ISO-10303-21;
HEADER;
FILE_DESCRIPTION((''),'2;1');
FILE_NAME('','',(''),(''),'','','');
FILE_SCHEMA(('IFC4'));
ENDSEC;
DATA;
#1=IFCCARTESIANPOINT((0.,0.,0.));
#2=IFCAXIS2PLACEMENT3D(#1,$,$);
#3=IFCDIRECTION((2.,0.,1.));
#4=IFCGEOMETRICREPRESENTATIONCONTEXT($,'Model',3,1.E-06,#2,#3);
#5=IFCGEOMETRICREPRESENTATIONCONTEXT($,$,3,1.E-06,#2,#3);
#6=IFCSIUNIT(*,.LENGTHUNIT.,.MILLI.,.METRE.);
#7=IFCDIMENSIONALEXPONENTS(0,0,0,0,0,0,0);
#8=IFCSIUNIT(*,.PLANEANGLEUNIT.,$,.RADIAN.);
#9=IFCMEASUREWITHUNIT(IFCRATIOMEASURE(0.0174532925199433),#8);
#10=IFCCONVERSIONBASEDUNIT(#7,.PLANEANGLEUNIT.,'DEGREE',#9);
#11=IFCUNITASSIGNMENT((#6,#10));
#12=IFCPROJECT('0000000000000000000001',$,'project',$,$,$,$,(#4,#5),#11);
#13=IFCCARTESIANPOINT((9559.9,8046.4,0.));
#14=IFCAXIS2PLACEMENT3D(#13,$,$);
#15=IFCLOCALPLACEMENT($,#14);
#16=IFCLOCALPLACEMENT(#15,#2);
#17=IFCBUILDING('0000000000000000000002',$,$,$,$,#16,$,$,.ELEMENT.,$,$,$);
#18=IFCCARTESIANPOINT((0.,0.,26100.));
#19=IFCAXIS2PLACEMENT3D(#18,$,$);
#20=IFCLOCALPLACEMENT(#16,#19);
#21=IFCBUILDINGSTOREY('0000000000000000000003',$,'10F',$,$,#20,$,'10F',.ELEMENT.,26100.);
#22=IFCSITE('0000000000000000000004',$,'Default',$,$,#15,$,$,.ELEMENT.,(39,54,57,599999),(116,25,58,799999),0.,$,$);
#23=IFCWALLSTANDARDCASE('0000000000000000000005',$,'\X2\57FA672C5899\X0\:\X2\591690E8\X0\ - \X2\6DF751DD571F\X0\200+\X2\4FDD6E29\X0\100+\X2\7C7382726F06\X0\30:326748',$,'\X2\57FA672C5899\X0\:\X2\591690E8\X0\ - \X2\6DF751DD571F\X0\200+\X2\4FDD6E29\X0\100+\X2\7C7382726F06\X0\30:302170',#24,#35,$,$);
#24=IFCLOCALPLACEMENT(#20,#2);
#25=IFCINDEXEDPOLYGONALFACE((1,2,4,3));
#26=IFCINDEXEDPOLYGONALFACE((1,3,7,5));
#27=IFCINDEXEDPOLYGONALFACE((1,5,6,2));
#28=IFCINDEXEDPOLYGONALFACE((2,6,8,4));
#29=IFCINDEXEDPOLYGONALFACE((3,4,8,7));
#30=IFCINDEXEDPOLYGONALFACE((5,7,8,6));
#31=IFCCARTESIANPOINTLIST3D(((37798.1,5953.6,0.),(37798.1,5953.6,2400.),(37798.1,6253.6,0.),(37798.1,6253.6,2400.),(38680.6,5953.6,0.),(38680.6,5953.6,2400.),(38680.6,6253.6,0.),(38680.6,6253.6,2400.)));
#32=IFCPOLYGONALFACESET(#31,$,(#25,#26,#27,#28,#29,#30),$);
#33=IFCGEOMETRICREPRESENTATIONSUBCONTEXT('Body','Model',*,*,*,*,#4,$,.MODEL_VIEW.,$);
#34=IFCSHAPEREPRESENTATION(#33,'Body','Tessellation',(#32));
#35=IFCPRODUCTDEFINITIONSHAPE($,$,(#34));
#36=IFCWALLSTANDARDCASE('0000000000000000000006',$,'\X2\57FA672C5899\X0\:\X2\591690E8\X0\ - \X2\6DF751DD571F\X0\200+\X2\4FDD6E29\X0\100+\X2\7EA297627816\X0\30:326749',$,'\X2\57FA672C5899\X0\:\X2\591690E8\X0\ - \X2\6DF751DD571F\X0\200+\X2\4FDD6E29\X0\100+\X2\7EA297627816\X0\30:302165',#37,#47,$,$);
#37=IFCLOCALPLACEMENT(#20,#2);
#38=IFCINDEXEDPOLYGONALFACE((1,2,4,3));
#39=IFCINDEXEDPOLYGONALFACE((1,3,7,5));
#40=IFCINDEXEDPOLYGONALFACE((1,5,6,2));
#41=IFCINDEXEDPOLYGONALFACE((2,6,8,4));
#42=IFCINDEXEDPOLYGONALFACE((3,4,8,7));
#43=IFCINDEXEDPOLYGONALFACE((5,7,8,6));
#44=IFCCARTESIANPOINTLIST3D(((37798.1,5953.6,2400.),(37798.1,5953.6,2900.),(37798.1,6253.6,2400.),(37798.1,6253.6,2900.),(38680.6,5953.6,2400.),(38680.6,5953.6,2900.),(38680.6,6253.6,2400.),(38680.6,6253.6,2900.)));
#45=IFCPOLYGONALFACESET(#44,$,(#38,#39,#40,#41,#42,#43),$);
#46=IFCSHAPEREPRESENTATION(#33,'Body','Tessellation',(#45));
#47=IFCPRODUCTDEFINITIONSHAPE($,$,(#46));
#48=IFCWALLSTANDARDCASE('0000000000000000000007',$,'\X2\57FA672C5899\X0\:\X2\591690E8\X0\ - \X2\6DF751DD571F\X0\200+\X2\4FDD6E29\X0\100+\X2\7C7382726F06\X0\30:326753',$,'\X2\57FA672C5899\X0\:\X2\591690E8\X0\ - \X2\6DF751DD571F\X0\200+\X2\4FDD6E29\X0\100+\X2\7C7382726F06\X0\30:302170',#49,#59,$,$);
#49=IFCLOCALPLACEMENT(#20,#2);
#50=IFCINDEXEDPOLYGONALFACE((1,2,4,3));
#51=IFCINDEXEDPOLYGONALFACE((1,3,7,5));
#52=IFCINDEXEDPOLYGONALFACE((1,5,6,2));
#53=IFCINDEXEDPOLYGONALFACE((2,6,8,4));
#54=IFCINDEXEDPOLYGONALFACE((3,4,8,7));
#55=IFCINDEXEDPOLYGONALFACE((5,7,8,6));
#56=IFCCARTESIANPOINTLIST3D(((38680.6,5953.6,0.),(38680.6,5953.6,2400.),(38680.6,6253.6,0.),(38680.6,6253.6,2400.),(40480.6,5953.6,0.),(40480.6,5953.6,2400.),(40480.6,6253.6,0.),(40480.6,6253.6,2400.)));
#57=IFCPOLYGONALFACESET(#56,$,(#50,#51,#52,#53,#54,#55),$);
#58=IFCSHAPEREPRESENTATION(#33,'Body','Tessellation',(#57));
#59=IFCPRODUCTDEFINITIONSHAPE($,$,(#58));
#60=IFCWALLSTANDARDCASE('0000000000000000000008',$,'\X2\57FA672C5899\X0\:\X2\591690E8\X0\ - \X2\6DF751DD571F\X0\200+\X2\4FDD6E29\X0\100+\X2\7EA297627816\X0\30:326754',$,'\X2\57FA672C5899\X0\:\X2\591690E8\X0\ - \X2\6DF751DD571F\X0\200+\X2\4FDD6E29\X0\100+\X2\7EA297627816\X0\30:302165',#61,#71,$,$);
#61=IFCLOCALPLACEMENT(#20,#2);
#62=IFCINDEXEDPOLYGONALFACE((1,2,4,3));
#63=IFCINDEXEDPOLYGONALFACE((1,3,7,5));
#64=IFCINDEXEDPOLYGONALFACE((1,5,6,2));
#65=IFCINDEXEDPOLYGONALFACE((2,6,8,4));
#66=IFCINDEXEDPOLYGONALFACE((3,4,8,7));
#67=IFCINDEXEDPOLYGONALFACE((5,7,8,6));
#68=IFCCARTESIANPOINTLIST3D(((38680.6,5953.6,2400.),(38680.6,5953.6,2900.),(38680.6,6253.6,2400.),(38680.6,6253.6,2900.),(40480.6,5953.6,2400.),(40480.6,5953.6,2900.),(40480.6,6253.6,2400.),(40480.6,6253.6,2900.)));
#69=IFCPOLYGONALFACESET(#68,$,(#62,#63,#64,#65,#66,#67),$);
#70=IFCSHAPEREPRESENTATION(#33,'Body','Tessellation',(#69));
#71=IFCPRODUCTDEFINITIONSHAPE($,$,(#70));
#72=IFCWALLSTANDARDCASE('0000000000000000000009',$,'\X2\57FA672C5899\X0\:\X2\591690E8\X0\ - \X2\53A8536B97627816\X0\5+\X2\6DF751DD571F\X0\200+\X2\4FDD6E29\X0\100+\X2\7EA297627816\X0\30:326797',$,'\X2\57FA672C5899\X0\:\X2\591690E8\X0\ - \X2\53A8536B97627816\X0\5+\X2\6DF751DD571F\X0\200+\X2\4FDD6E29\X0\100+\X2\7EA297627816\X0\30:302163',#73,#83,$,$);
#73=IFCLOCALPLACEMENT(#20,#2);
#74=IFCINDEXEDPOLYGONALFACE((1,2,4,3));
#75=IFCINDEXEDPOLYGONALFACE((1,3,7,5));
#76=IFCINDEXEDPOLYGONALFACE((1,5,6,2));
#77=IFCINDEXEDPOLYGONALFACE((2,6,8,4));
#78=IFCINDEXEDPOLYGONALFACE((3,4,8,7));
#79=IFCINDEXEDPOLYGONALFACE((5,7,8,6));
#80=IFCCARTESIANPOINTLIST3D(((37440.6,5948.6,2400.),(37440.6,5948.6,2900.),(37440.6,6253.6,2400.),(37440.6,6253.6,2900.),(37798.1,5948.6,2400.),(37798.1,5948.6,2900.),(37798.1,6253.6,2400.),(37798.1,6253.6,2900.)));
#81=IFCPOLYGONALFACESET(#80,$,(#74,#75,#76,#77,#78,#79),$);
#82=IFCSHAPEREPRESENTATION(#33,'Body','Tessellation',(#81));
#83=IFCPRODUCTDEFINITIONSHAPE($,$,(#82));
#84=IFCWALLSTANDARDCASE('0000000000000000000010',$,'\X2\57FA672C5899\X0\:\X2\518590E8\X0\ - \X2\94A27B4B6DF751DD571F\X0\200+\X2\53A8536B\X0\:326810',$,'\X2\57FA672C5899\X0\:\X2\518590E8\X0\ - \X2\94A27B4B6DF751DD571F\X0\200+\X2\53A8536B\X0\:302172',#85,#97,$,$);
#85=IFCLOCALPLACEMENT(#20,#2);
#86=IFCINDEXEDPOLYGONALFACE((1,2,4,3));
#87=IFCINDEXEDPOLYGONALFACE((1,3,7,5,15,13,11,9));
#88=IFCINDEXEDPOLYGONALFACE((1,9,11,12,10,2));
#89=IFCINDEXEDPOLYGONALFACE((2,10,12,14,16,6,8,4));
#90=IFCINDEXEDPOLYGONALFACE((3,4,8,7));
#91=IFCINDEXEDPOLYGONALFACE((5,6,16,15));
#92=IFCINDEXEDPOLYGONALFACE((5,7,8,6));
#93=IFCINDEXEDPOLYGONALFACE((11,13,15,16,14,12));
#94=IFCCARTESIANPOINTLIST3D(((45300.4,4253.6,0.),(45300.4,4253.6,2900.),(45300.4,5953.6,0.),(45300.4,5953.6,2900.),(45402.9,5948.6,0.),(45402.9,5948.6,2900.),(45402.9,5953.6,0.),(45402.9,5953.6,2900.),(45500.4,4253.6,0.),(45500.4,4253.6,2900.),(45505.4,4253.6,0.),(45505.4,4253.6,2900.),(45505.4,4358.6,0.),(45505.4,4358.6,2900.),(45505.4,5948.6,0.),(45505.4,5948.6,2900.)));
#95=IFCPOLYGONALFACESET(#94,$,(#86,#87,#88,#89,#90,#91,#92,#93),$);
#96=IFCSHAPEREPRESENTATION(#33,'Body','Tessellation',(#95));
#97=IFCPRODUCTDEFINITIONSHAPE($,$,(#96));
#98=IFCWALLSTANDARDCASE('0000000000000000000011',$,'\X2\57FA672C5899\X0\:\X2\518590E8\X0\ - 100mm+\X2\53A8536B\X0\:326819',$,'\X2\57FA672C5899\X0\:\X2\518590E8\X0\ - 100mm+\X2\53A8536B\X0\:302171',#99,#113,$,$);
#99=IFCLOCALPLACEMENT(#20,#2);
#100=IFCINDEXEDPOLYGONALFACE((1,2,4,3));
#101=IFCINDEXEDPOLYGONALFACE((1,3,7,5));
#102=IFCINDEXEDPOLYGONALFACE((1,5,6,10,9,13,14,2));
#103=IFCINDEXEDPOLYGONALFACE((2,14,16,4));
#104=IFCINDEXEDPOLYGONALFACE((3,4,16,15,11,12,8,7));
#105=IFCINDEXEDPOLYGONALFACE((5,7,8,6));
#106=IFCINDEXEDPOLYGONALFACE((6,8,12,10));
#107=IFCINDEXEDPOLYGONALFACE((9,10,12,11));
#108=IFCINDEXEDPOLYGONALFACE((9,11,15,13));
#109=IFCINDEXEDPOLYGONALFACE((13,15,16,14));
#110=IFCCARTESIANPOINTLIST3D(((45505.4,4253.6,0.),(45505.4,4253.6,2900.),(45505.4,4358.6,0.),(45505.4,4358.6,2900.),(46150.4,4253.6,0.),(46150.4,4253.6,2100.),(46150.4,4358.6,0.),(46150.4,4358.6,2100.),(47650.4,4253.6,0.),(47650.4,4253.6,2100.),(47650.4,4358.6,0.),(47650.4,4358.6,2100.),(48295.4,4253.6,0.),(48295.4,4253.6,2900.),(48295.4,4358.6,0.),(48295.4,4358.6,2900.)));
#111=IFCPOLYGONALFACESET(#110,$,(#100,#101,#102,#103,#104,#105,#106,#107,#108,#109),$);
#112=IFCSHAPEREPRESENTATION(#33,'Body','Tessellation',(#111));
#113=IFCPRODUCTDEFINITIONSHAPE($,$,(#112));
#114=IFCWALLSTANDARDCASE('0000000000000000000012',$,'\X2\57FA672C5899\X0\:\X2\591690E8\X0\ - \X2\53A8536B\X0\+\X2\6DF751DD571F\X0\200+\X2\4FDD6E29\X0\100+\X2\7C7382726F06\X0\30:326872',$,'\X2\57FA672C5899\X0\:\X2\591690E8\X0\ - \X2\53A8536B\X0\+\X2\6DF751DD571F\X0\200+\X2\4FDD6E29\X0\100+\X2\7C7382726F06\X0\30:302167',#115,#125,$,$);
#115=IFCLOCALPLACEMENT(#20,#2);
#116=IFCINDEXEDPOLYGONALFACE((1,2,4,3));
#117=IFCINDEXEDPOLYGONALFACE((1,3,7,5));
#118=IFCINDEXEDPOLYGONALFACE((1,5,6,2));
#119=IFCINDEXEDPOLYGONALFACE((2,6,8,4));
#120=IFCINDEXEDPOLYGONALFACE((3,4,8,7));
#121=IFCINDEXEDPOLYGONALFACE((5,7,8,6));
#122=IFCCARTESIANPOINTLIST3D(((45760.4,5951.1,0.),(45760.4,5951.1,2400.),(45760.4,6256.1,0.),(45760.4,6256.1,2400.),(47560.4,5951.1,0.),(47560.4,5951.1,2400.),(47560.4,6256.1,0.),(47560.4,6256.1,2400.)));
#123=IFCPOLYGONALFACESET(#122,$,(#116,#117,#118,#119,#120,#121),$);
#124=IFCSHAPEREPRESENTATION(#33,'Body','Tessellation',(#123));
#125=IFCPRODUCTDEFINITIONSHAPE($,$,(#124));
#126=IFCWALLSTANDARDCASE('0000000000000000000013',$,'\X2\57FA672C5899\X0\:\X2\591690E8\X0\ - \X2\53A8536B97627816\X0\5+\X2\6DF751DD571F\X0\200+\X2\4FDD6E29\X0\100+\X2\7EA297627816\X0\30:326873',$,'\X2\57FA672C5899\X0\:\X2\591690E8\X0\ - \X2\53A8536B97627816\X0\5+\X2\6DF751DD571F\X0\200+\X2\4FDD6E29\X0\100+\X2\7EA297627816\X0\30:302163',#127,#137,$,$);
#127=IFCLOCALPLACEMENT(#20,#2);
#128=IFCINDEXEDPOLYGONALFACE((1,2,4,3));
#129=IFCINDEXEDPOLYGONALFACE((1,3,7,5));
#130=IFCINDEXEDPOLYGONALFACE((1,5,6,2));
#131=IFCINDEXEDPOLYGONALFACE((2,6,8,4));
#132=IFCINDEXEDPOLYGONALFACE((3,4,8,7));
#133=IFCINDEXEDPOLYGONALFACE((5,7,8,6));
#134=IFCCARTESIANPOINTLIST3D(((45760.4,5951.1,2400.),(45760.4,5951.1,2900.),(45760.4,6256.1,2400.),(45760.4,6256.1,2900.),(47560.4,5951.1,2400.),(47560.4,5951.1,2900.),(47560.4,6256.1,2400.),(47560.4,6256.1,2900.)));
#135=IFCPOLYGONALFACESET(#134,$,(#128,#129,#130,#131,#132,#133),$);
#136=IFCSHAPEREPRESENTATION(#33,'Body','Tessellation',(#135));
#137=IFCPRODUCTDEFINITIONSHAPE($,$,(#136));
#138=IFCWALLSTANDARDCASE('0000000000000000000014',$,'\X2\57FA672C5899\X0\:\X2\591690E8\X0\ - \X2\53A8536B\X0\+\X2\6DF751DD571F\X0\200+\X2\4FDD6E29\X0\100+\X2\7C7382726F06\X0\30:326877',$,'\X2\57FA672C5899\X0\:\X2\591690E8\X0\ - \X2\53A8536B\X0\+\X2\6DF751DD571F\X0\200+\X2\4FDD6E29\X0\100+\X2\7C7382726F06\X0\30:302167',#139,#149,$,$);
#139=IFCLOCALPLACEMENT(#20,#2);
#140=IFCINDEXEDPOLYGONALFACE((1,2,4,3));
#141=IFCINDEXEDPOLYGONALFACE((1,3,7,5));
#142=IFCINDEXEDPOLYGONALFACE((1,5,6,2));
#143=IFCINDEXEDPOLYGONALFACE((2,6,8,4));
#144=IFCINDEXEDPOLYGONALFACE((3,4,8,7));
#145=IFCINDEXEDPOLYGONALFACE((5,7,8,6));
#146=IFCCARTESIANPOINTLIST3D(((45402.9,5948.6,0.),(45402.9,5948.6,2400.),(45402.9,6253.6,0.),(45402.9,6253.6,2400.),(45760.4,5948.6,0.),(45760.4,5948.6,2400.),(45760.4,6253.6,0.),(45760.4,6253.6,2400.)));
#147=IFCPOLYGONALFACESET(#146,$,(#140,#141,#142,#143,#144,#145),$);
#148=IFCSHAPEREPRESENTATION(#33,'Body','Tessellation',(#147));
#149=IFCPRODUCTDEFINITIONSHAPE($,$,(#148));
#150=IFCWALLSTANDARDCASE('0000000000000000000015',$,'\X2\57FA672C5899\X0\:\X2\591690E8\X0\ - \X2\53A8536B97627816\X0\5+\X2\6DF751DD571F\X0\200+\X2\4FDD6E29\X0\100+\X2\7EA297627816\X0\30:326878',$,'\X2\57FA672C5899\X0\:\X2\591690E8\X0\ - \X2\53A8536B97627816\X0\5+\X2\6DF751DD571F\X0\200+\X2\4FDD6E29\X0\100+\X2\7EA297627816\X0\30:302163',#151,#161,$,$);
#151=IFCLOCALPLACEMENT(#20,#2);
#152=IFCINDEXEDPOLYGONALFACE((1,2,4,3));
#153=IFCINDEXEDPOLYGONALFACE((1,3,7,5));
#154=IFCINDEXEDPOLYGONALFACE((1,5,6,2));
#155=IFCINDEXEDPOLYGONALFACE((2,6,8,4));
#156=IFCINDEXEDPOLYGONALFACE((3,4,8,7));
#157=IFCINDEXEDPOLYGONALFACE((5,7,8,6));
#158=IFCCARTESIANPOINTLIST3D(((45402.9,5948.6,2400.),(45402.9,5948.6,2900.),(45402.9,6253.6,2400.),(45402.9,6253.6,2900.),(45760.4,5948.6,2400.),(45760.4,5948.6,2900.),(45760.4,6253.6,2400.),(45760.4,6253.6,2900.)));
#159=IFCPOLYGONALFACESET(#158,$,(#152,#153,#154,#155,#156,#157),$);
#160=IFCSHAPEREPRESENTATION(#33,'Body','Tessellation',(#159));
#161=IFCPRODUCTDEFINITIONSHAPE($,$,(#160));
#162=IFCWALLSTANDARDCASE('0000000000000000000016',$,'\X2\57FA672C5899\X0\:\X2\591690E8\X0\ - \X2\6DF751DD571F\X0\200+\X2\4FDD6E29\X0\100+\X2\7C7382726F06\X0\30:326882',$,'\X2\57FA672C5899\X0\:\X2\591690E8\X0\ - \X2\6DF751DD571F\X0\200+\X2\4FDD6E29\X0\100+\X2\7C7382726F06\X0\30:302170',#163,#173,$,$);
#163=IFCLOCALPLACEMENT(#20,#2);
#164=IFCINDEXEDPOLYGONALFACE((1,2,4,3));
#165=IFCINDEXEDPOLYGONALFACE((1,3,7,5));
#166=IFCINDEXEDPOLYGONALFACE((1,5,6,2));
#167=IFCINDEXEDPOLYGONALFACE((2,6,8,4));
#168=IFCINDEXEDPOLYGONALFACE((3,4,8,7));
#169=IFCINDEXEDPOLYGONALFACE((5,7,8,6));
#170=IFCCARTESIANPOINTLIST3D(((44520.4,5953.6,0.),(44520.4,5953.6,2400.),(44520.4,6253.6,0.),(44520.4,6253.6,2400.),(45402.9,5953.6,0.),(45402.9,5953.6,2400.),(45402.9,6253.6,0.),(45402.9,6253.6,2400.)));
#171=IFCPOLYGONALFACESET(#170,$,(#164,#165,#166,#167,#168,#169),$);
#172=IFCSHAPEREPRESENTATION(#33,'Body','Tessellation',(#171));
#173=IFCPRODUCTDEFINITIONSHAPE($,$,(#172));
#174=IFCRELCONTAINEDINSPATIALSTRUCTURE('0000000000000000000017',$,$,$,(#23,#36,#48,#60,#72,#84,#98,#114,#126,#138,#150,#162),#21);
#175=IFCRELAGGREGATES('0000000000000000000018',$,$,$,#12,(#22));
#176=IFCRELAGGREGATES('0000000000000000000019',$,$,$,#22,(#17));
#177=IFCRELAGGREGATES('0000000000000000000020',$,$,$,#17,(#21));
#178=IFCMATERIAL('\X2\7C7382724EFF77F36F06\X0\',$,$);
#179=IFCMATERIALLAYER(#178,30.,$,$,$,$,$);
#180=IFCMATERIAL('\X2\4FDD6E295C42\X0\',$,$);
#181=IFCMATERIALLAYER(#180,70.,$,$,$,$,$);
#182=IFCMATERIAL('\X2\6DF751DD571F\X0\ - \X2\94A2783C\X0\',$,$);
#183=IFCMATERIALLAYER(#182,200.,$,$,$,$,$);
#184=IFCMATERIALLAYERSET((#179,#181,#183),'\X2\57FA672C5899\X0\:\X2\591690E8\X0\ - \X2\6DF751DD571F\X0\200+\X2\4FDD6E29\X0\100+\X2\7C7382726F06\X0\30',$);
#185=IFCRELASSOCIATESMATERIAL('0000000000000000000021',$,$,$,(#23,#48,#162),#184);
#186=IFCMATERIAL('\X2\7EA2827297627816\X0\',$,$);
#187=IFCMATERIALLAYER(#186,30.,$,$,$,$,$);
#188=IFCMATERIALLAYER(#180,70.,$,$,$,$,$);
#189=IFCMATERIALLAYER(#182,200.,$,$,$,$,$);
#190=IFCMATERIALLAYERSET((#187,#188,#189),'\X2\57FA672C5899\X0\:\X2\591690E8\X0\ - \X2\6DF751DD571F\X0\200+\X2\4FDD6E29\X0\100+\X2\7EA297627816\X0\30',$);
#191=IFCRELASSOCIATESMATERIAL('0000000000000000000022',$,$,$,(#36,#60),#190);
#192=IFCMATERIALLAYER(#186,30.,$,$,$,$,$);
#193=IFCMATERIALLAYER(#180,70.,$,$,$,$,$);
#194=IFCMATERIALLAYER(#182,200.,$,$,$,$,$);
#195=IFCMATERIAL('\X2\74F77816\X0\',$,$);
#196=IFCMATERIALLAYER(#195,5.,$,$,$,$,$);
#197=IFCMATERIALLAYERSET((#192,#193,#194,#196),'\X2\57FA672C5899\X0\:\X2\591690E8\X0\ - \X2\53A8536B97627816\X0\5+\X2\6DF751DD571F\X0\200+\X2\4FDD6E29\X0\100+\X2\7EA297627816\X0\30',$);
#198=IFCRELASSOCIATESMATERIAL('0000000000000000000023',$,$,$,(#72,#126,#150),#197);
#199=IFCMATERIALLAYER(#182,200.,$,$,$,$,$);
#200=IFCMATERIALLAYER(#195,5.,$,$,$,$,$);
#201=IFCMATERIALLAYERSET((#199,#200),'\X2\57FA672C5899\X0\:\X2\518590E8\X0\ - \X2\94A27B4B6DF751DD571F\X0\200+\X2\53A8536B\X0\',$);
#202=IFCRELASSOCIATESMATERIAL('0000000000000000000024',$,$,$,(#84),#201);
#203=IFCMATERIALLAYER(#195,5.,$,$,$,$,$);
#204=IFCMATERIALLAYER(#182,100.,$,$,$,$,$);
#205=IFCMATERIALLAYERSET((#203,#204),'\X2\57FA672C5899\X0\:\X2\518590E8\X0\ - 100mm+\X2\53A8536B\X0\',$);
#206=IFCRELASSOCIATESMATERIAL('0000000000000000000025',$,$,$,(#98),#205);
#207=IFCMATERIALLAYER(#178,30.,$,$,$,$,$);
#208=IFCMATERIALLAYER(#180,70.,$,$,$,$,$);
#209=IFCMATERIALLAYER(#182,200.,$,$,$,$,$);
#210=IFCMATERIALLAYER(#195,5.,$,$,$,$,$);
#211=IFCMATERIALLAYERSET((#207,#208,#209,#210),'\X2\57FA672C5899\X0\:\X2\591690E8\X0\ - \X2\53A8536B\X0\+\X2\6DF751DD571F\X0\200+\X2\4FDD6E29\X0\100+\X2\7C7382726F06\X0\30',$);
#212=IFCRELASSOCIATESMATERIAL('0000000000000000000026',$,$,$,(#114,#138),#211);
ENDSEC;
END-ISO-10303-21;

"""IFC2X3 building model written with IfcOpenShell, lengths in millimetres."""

from ifc_helpers import new_model, entity, si_unit, converted_unit, direction, frame, frame_2d, origin, place, context, subcontext, project, spatial, polyline, rectangle, outline, extrude, material, layer, layer_set, layer_usage, element, save


model = new_model("IFC2X3")

# Units and contexts
model_context = context("Model", 3, precision=1e-06, world=origin(), true_north=direction((2.0, 0.0, 1.0)))
context_of_model = context(None, 3, precision=1e-06, world=origin(), true_north=direction((2.0, 0.0, 1.0)))
body_context = subcontext(model_context, "Body", "Model", "MODEL_VIEW")
ifc_project = project(units=[si_unit("LENGTHUNIT", "METRE", prefix="MILLI"), converted_unit("PLANEANGLEUNIT", "DEGREE", entity("IfcRatioMeasure", 0.0174532925199433), si_unit("PLANEANGLEUNIT", "RADIAN"), dimensions=[0, 0, 0, 0, 0, 0, 0])], contexts=[model_context, context_of_model])

# Site, building, storey
site_placement = place(None, frame((9559.9, 8046.4, 0.0)))
site = spatial("IfcSite", under=ifc_project, at=site_placement, Name="Default", CompositionType="ELEMENT", RefLatitude=(39, 54, 57, 599999), RefLongitude=(116, 25, 58, 799999), RefElevation=0.0)
building_placement = place(site_placement, origin())
building = spatial("IfcBuilding", under=site, at=building_placement, CompositionType="ELEMENT")
storey_placement = place(building_placement, frame((0.0, 0.0, 26100.0)))
storey = spatial("IfcBuildingStorey", under=building, at=storey_placement, Name="10F", LongName="10F", CompositionType="ELEMENT", Elevation=26100.0)

# Shared definitions
ifc_material_1 = material(Name="红色面砖")
ifc_layer_1 = layer(ifc_material_1, 30.0)
ifc_material_2 = material(Name="保温层")
ifc_layer_2 = layer(ifc_material_2, 70.0)
ifc_material_3 = material(Name="混凝土 - 钢砼")
ifc_layer_3 = layer(ifc_material_3, 200.0)
ifc_layer_set_1 = layer_set([ifc_layer_1, ifc_layer_2, ifc_layer_3], Name="基本墙:外部 - 混凝土200+保温100+红面砖30")

# Walls
ifc_material_4 = material(Name="米色仿石漆")
ifc_layer_4 = layer(ifc_material_4, 30.0)
ifc_layer_5 = layer(ifc_material_2, 70.0)
ifc_layer_6 = layer(ifc_material_3, 200.0)
ifc_layer_set_2 = layer_set([ifc_layer_4, ifc_layer_5, ifc_layer_6], Name="基本墙:外部 - 混凝土200+保温100+米色漆30")
ifc_layer_usage_1 = layer_usage(ifc_layer_set_2, "AXIS2", "POSITIVE", -150.0)
wall_1_placement = place(storey_placement, frame((38680.6, 6103.6, 0.0), z_axis=(0.0, 0.0, 1.0), x_axis=(-1.0, 0.0, 0.0)))
element("IfcWallStandardCase", 1, at=wall_1_placement, inside=storey, material=ifc_layer_usage_1, Name="基本墙:外部 - 混凝土200+保温100+米色漆30:326748", ObjectType="基本墙:外部 - 混凝土200+保温100+米色漆30:302170", context=body_context, shape_type="SweptSolid", body=[
    extrude(rectangle(XDim=882.5, YDim=300.0, at=frame_2d((441.3, 0.0), x_axis=(-1.0, 0.0))), origin(), (0.0, 0.0, 1.0), 2400.0),
])
ifc_layer_usage_2 = layer_usage(ifc_layer_set_1, "AXIS2", "POSITIVE", -150.0)
wall_2_placement = place(storey_placement, frame((38680.6, 6103.6, 2400.0), z_axis=(0.0, 0.0, 1.0), x_axis=(-1.0, 0.0, 0.0)))
element("IfcWallStandardCase", 2, at=wall_2_placement, inside=storey, material=ifc_layer_usage_2, Name="基本墙:外部 - 混凝土200+保温100+红面砖30:326749", ObjectType="基本墙:外部 - 混凝土200+保温100+红面砖30:302165", context=body_context, shape_type="SweptSolid", body=[
    extrude(rectangle(XDim=882.5, YDim=300.0, at=frame_2d((441.3, 0.0), x_axis=(-1.0, 0.0))), origin(), (0.0, 0.0, 1.0), 500.0),
])
ifc_layer_usage_3 = layer_usage(ifc_layer_set_2, "AXIS2", "POSITIVE", -150.0)
wall_3_placement = place(storey_placement, frame((40480.6, 6103.6, 0.0), z_axis=(0.0, 0.0, 1.0), x_axis=(-1.0, 0.0, 0.0)))
element("IfcWallStandardCase", 3, at=wall_3_placement, inside=storey, material=ifc_layer_usage_3, Name="基本墙:外部 - 混凝土200+保温100+米色漆30:326753", ObjectType="基本墙:外部 - 混凝土200+保温100+米色漆30:302170", context=body_context, shape_type="SweptSolid", body=[
    extrude(rectangle(XDim=1800.0, YDim=300.0, at=frame_2d((900.0, 0.0), x_axis=(-1.0, 0.0))), origin(), (0.0, 0.0, 1.0), 2400.0),
])
ifc_layer_usage_4 = layer_usage(ifc_layer_set_1, "AXIS2", "POSITIVE", -150.0)
wall_4_placement = place(storey_placement, frame((40480.6, 6103.6, 2400.0), z_axis=(0.0, 0.0, 1.0), x_axis=(-1.0, 0.0, 0.0)))
element("IfcWallStandardCase", 4, at=wall_4_placement, inside=storey, material=ifc_layer_usage_4, Name="基本墙:外部 - 混凝土200+保温100+红面砖30:326754", ObjectType="基本墙:外部 - 混凝土200+保温100+红面砖30:302165", context=body_context, shape_type="SweptSolid", body=[
    extrude(rectangle(XDim=1800.0, YDim=300.0, at=frame_2d((900.0, 0.0), x_axis=(-1.0, 0.0))), origin(), (0.0, 0.0, 1.0), 500.0),
])
ifc_layer_7 = layer(ifc_material_1, 30.0)
ifc_layer_8 = layer(ifc_material_2, 70.0)
ifc_layer_9 = layer(ifc_material_3, 200.0)
ifc_material_5 = material(Name="瓷砖")
ifc_layer_10 = layer(ifc_material_5, 5.0)
ifc_layer_set_3 = layer_set([ifc_layer_7, ifc_layer_8, ifc_layer_9, ifc_layer_10], Name="基本墙:外部 - 厨卫面砖5+混凝土200+保温100+红面砖30")
ifc_layer_usage_5 = layer_usage(ifc_layer_set_3, "AXIS2", "POSITIVE", -152.5)
wall_5_placement = place(storey_placement, frame((37798.1, 6101.1, 2400.0), z_axis=(0.0, 0.0, 1.0), x_axis=(-1.0, 0.0, 0.0)))
element("IfcWallStandardCase", 5, at=wall_5_placement, inside=storey, material=ifc_layer_usage_5, Name="基本墙:外部 - 厨卫面砖5+混凝土200+保温100+红面砖30:326797", ObjectType="基本墙:外部 - 厨卫面砖5+混凝土200+保温100+红面砖30:302163", context=body_context, shape_type="SweptSolid", body=[
    extrude(rectangle(XDim=357.5, YDim=305.0, at=frame_2d((178.7, 0.0), x_axis=(-1.0, 0.0))), origin(), (0.0, 0.0, 1.0), 500.0),
])

# Wall
ifc_layer_11 = layer(ifc_material_3, 200.0)
ifc_layer_12 = layer(ifc_material_5, 5.0)
ifc_layer_set_4 = layer_set([ifc_layer_11, ifc_layer_12], Name="基本墙:内部 - 钢筋混凝土200+厨卫")
ifc_layer_usage_6 = layer_usage(ifc_layer_set_4, "AXIS2", "POSITIVE", -102.5)
wall_6_placement = place(storey_placement, frame((45402.9, 5953.6, 0.0), z_axis=(0.0, 0.0, 1.0), x_axis=(0.0, -1.0, 0.0)))
element("IfcWallStandardCase", 6, at=wall_6_placement, inside=storey, material=ifc_layer_usage_6, Name="基本墙:内部 - 钢筋混凝土200+厨卫:326810", ObjectType="基本墙:内部 - 钢筋混凝土200+厨卫:302172", context=body_context, shape_type="SweptSolid", body=[
    extrude(outline(polyline([(1700.0, -102.5), (1700.0, 97.5), (1700.0, 102.5), (1595.0, 102.5), (5.0, 102.5), (5.0, 0.0), (0.0, 0.0), (0.0, -102.5), (1700.0, -102.5)])), origin(), (0.0, 0.0, 1.0), 2900.0),
])

# Wall, opening
ifc_layer_13 = layer(ifc_material_5, 5.0)
ifc_layer_14 = layer(ifc_material_3, 100.0)
ifc_layer_set_5 = layer_set([ifc_layer_13, ifc_layer_14], Name="基本墙:内部 - 100mm+厨卫")
ifc_layer_usage_7 = layer_usage(ifc_layer_set_5, "AXIS2", "NEGATIVE", 52.5)
wall_7_placement = place(storey_placement, frame((45505.4, 4306.1, 0.0)))
wall_7 = element("IfcWallStandardCase", 7, at=wall_7_placement, inside=storey, material=ifc_layer_usage_7, Name="基本墙:内部 - 100mm+厨卫:326819", ObjectType="基本墙:内部 - 100mm+厨卫:302171", context=body_context, shape_type="SweptSolid", body=[
    extrude(rectangle(XDim=2790.0, YDim=105.0, at=frame_2d((1395.0, 0.0), x_axis=(-1.0, 0.0))), origin(), (0.0, 0.0, 1.0), 2900.0),
])
opening_1_placement = place(wall_7_placement, frame((645.0, -52.5, 0.0)))
element("IfcOpeningElement", 8, at=opening_1_placement, cuts=wall_7, ObjectType="Opening", context=body_context, shape_type="SweptSolid", body=[
    extrude(rectangle(XDim=2100.0, YDim=1500.0, at=frame_2d((1050.0, 750.0), x_axis=(1.0, 0.0))), frame((0.0, 0.0, 0.0), z_axis=(0.0, 1.0, 0.0), x_axis=(0.0, 0.0, 1.0)), (0.0, 0.0, 1.0), 105.0),
])

# Walls
ifc_layer_15 = layer(ifc_material_4, 30.0)
ifc_layer_16 = layer(ifc_material_2, 70.0)
ifc_layer_17 = layer(ifc_material_3, 200.0)
ifc_layer_18 = layer(ifc_material_5, 5.0)
ifc_layer_set_6 = layer_set([ifc_layer_15, ifc_layer_16, ifc_layer_17, ifc_layer_18], Name="基本墙:外部 - 厨卫+混凝土200+保温100+米色漆30")
ifc_layer_usage_8 = layer_usage(ifc_layer_set_6, "AXIS2", "NEGATIVE", 152.5)
wall_8_placement = place(storey_placement, frame((45760.4, 6103.6, 0.0)))
element("IfcWallStandardCase", 9, at=wall_8_placement, inside=storey, material=ifc_layer_usage_8, Name="基本墙:外部 - 厨卫+混凝土200+保温100+米色漆30:326872", ObjectType="基本墙:外部 - 厨卫+混凝土200+保温100+米色漆30:302167", context=body_context, shape_type="SweptSolid", body=[
    extrude(rectangle(XDim=1800.0, YDim=305.0, at=frame_2d((900.0, 0.0), x_axis=(-1.0, 0.0))), origin(), (0.0, 0.0, 1.0), 2400.0),
])
ifc_layer_usage_9 = layer_usage(ifc_layer_set_3, "AXIS2", "NEGATIVE", 152.5)
wall_9_placement = place(storey_placement, frame((45760.4, 6103.6, 2400.0)))
element("IfcWallStandardCase", 10, at=wall_9_placement, inside=storey, material=ifc_layer_usage_9, Name="基本墙:外部 - 厨卫面砖5+混凝土200+保温100+红面砖30:326873", ObjectType="基本墙:外部 - 厨卫面砖5+混凝土200+保温100+红面砖30:302163", context=body_context, shape_type="SweptSolid", body=[
    extrude(rectangle(XDim=1800.0, YDim=305.0, at=frame_2d((900.0, 0.0), x_axis=(-1.0, 0.0))), origin(), (0.0, 0.0, 1.0), 500.0),
])
ifc_layer_usage_10 = layer_usage(ifc_layer_set_6, "AXIS2", "NEGATIVE", 152.5)
wall_10_placement = place(storey_placement, frame((45402.9, 6101.1, 0.0)))
element("IfcWallStandardCase", 11, at=wall_10_placement, inside=storey, material=ifc_layer_usage_10, Name="基本墙:外部 - 厨卫+混凝土200+保温100+米色漆30:326877", ObjectType="基本墙:外部 - 厨卫+混凝土200+保温100+米色漆30:302167", context=body_context, shape_type="SweptSolid", body=[
    extrude(rectangle(XDim=357.5, YDim=305.0, at=frame_2d((178.7, 0.0), x_axis=(-1.0, 0.0))), origin(), (0.0, 0.0, 1.0), 2400.0),
])
ifc_layer_usage_11 = layer_usage(ifc_layer_set_3, "AXIS2", "NEGATIVE", 152.5)
wall_11_placement = place(storey_placement, frame((45402.9, 6101.1, 2400.0)))
element("IfcWallStandardCase", 12, at=wall_11_placement, inside=storey, material=ifc_layer_usage_11, Name="基本墙:外部 - 厨卫面砖5+混凝土200+保温100+红面砖30:326878", ObjectType="基本墙:外部 - 厨卫面砖5+混凝土200+保温100+红面砖30:302163", context=body_context, shape_type="SweptSolid", body=[
    extrude(rectangle(XDim=357.5, YDim=305.0, at=frame_2d((178.7, 0.0), x_axis=(-1.0, 0.0))), origin(), (0.0, 0.0, 1.0), 500.0),
])
ifc_layer_usage_12 = layer_usage(ifc_layer_set_2, "AXIS2", "NEGATIVE", 150.0)
wall_12_placement = place(storey_placement, frame((44520.4, 6103.6, 0.0)))
element("IfcWallStandardCase", 13, at=wall_12_placement, inside=storey, material=ifc_layer_usage_12, Name="基本墙:外部 - 混凝土200+保温100+米色漆30:326882", ObjectType="基本墙:外部 - 混凝土200+保温100+米色漆30:302170", context=body_context, shape_type="SweptSolid", body=[
    extrude(rectangle(XDim=882.5, YDim=300.0, at=frame_2d((441.2, 0.0), x_axis=(-1.0, 0.0))), origin(), (0.0, 0.0, 1.0), 2400.0),
])

save(model, "model.ifc")
